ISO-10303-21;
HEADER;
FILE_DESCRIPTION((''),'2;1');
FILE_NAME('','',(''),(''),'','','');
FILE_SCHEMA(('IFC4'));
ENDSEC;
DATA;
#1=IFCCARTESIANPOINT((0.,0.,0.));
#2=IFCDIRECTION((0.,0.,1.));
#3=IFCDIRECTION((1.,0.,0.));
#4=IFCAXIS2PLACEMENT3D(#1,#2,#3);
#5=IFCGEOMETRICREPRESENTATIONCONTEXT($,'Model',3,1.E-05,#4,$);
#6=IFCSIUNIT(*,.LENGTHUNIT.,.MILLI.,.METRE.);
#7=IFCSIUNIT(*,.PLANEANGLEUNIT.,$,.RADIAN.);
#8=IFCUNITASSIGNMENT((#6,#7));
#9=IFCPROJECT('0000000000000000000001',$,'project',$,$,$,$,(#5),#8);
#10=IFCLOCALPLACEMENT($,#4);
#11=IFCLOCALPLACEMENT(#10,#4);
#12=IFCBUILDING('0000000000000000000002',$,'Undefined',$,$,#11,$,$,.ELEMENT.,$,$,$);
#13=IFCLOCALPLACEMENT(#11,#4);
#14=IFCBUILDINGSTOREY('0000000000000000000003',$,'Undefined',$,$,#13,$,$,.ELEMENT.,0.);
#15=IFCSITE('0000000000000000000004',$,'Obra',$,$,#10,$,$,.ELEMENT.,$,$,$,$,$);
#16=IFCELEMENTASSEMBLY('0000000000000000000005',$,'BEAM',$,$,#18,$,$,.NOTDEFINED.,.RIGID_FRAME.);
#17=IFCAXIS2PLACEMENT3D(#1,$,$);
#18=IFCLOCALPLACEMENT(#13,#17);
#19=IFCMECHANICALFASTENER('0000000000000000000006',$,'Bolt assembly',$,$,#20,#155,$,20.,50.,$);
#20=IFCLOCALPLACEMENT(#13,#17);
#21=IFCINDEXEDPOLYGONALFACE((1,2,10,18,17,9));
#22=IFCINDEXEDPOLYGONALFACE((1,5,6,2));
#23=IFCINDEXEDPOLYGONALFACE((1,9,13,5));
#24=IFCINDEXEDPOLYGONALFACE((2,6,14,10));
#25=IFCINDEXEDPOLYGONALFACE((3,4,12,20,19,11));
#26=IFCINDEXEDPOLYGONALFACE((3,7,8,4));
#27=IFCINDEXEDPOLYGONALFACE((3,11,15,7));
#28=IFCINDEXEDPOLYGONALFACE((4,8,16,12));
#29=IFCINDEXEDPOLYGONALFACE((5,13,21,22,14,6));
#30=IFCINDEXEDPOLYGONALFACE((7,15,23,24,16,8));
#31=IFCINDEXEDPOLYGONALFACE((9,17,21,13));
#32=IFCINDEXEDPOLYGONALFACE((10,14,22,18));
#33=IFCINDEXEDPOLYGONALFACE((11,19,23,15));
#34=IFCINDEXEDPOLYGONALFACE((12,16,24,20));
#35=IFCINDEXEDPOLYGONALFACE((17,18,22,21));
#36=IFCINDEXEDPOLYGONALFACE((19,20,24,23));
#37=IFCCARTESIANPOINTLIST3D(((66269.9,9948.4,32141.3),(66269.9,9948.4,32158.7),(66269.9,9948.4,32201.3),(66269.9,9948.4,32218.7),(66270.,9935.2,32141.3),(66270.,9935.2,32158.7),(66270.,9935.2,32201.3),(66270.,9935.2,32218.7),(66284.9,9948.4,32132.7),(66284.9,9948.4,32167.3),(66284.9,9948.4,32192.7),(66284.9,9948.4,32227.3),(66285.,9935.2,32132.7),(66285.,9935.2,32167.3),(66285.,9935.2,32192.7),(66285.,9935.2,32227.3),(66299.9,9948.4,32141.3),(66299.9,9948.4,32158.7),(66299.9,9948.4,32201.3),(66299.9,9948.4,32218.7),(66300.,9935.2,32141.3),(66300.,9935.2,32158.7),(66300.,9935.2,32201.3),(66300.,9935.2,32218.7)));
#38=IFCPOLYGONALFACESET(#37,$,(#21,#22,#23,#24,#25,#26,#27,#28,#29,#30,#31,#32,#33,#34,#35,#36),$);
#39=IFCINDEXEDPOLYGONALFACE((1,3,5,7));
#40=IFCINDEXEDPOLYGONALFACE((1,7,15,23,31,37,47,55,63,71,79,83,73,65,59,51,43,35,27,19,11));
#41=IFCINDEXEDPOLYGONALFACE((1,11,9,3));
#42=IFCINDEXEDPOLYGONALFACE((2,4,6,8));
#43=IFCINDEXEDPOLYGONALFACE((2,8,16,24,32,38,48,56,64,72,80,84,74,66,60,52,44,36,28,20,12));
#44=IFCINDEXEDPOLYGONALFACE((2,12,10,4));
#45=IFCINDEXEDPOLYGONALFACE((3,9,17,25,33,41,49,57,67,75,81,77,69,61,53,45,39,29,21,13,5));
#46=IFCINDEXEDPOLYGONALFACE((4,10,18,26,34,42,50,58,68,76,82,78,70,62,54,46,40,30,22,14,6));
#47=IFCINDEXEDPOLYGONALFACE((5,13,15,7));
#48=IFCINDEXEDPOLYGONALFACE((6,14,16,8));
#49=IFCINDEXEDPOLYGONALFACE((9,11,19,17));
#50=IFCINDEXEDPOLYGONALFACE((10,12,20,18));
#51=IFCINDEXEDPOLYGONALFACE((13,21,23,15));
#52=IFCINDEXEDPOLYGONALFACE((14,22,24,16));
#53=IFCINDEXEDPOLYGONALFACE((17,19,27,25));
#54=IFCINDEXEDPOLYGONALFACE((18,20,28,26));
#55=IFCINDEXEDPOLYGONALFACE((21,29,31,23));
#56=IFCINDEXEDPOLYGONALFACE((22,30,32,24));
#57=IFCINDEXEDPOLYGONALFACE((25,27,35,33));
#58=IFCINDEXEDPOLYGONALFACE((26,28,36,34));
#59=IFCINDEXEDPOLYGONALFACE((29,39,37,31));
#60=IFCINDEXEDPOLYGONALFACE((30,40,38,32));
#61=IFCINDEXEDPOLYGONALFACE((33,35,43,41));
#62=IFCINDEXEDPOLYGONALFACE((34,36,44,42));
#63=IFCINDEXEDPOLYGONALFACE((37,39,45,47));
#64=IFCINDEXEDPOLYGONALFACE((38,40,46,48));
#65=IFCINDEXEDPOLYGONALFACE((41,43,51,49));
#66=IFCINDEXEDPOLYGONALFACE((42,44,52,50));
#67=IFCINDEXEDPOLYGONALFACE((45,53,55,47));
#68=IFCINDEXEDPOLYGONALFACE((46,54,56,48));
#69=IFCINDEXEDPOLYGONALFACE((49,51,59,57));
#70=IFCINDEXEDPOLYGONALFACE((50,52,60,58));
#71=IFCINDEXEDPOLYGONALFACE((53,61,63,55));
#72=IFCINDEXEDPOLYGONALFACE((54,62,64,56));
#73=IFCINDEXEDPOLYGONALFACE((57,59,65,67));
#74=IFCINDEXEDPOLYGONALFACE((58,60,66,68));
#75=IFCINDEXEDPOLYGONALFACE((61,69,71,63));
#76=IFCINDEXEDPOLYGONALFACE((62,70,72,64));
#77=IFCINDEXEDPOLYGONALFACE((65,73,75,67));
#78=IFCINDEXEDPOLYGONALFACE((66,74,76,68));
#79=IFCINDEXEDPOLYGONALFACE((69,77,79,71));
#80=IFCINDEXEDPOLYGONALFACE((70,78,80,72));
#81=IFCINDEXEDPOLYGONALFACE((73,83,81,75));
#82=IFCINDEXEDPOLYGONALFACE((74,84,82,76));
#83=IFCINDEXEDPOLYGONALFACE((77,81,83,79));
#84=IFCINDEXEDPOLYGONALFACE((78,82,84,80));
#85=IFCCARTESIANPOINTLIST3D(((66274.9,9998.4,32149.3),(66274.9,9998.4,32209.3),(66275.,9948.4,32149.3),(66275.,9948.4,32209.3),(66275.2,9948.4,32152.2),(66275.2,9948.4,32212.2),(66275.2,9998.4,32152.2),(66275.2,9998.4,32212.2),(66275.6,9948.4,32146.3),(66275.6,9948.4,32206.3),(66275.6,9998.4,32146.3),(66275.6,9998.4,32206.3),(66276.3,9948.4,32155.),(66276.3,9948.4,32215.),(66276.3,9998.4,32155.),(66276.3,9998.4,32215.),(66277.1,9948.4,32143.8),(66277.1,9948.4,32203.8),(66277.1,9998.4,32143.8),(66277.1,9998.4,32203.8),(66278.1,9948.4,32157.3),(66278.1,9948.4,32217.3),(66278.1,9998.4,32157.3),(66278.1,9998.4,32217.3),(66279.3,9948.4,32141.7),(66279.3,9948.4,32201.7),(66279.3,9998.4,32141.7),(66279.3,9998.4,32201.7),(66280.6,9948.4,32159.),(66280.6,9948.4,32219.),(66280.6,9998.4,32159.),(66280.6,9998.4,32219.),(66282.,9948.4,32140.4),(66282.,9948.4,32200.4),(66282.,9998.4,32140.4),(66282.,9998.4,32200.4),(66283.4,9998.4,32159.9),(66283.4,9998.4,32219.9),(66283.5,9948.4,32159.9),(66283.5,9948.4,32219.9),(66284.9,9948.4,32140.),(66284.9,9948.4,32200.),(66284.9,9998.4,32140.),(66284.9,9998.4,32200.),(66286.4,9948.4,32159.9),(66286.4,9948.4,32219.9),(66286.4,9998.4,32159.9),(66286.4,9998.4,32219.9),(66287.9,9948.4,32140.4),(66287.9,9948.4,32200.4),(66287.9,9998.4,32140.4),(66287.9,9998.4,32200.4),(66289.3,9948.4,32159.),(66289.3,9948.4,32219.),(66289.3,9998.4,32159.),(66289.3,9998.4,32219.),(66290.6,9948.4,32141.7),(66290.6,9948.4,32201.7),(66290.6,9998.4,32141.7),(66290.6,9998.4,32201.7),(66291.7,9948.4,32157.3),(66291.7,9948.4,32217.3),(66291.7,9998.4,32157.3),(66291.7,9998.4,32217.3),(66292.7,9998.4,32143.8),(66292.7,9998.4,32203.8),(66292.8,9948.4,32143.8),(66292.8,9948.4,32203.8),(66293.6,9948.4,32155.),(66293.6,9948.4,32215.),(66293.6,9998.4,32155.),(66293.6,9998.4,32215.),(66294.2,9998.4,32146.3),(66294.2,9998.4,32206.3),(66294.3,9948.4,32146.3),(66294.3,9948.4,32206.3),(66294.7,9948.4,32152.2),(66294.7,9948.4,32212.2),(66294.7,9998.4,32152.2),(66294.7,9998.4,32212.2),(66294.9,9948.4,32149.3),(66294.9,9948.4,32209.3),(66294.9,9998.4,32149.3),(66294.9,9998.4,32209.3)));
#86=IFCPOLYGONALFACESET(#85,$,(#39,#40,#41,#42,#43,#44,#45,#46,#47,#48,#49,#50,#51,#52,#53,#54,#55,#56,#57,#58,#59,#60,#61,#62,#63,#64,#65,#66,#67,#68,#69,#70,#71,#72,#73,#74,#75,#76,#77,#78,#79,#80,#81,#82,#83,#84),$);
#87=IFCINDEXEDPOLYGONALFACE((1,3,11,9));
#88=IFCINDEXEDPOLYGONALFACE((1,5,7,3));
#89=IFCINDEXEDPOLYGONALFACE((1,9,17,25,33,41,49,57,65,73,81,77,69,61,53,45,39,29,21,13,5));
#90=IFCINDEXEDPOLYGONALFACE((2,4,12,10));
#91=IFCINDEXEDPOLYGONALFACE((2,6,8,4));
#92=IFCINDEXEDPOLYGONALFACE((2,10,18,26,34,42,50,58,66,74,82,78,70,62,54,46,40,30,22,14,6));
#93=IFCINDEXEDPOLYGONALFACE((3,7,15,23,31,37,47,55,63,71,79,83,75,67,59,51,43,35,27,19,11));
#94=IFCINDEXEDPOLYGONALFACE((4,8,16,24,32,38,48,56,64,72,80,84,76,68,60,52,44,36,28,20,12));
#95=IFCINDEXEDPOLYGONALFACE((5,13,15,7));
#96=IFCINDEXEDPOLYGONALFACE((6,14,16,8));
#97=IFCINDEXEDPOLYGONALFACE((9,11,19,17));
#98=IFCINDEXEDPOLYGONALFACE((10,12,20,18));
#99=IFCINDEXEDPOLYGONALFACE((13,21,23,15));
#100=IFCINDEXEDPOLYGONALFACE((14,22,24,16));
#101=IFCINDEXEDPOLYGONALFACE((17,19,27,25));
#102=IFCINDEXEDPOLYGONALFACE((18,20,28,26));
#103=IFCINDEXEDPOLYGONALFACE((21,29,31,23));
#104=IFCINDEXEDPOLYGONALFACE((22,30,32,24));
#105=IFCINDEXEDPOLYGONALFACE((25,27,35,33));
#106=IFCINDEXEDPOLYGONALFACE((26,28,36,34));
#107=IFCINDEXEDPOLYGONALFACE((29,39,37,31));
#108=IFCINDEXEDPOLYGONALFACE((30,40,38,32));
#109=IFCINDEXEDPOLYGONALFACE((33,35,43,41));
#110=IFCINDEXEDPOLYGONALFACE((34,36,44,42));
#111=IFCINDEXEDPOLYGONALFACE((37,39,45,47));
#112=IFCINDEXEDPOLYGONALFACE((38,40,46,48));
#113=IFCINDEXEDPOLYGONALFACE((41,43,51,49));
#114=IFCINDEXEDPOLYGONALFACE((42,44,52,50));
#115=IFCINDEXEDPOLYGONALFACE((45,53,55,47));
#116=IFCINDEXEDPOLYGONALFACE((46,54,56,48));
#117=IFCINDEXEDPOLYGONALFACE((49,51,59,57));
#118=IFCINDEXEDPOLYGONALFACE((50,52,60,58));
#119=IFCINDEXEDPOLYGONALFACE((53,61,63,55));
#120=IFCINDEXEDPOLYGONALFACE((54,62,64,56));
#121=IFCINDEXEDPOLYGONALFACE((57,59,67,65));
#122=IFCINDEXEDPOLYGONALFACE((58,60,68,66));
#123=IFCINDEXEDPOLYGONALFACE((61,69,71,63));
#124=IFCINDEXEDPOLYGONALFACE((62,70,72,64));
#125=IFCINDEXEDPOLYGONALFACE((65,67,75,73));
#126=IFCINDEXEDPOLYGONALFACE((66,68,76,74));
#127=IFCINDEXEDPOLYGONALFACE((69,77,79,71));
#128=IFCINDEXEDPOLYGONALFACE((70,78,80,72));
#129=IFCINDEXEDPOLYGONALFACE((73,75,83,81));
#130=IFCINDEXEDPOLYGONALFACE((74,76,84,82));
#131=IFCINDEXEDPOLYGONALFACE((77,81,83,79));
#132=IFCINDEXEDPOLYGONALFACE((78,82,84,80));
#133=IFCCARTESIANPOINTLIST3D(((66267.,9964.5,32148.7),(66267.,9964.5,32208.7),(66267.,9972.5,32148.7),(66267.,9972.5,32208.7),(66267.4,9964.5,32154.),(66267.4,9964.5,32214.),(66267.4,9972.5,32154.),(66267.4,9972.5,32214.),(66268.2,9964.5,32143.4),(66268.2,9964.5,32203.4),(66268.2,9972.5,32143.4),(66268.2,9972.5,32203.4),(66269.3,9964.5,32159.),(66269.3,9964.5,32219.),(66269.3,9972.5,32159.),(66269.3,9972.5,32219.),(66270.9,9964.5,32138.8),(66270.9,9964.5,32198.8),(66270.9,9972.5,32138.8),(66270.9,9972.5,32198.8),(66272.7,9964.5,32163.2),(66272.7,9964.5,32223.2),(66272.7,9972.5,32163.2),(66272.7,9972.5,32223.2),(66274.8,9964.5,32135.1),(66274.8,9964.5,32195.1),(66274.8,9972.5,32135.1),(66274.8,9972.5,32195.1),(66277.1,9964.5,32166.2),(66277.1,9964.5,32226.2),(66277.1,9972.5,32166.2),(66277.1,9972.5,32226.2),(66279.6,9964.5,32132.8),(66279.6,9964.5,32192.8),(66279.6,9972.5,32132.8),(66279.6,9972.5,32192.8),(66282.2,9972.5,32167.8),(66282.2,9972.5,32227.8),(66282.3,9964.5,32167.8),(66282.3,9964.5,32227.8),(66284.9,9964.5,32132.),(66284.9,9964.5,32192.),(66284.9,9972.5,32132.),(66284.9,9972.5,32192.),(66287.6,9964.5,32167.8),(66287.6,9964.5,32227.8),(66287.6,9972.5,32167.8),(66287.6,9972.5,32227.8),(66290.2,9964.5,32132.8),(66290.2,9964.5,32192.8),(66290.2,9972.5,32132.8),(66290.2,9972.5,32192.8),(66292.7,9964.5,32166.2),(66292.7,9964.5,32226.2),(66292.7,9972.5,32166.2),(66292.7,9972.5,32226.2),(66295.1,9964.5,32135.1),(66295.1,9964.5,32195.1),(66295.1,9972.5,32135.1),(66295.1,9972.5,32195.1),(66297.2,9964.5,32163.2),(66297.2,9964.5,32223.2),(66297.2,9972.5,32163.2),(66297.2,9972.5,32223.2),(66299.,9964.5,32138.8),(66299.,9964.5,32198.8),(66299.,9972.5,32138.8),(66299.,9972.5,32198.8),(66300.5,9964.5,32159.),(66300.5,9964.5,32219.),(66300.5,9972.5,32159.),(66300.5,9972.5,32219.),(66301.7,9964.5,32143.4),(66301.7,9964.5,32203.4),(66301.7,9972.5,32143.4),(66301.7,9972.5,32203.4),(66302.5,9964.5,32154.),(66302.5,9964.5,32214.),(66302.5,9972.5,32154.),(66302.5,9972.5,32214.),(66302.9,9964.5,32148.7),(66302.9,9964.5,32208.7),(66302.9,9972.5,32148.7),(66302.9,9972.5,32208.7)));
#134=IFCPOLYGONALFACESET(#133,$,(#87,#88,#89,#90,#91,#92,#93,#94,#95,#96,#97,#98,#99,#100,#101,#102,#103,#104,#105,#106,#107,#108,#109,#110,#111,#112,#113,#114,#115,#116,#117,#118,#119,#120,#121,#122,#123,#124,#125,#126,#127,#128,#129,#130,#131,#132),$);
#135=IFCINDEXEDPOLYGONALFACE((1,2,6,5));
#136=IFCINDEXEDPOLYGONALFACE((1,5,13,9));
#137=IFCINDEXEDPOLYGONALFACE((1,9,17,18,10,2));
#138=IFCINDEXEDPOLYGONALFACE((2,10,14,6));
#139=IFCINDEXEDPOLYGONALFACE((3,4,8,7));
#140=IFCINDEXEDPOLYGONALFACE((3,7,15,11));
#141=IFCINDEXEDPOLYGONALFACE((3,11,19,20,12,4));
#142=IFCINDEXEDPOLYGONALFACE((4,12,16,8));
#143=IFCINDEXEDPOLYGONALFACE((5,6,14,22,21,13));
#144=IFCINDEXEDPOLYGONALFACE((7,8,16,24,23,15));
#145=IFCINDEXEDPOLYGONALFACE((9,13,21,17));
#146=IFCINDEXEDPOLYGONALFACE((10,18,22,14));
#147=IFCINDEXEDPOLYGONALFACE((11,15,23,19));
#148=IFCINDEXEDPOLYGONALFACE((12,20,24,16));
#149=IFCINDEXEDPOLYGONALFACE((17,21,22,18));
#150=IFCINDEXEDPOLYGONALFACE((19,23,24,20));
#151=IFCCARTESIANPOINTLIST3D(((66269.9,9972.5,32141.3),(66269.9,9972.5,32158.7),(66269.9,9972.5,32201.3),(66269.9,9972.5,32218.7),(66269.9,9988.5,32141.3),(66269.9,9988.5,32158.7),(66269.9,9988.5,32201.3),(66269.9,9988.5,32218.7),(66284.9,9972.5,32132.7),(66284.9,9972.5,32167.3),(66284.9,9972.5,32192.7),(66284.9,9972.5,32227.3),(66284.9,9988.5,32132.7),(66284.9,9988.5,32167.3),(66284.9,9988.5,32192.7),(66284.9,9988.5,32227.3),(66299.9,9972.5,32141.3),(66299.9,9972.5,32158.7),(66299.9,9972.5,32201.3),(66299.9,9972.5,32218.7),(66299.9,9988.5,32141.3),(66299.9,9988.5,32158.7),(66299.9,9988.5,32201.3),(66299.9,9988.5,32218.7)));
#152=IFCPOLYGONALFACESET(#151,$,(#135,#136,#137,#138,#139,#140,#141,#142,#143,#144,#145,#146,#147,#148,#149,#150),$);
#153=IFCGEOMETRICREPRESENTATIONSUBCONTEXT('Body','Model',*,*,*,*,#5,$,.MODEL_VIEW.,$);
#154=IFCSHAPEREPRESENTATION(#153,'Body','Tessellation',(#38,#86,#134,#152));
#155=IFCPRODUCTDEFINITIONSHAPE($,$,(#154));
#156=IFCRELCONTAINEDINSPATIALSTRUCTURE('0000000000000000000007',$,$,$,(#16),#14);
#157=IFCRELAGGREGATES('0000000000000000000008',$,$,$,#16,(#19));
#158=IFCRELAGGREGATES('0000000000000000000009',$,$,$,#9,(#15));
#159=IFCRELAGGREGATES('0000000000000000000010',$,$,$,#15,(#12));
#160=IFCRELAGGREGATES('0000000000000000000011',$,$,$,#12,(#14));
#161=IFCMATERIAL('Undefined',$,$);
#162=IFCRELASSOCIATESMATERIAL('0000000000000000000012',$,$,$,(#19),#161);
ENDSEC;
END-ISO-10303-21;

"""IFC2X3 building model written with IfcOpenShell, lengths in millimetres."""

from ifc_helpers import new_model, si_unit, frame, origin_with_axes, origin_2d_with_axis, place, context, subcontext, project, spatial, polyline, circle, outline, extrude, source, transform, mapped, material, element, aggregate, save


model = new_model("IFC2X3")

# Units and contexts
model_context = context("Model", 3, precision=1e-05, world=origin_with_axes())
body_context = subcontext(model_context, "Body", "Model", "MODEL_VIEW")
ifc_project = project(units=[si_unit("LENGTHUNIT", "METRE", prefix="MILLI"), si_unit("PLANEANGLEUNIT", "RADIAN")], contexts=[model_context])

# Site, building, storey
site_placement = place(None, origin_with_axes())
site = spatial("IfcSite", under=ifc_project, at=site_placement, Name="Obra", CompositionType="ELEMENT")
building_placement = place(site_placement, origin_with_axes())
building = spatial("IfcBuilding", under=site, at=building_placement, Name="Undefined", CompositionType="ELEMENT")
storey_placement = place(building_placement, origin_with_axes())
storey = spatial("IfcBuildingStorey", under=building, at=storey_placement, Name="Undefined", CompositionType="ELEMENT", Elevation=0.0)

# Element assembly
assembly_1_placement = place(storey_placement, origin_with_axes())
assembly_1 = element("IfcElementAssembly", 1, at=assembly_1_placement, inside=storey, Name="BEAM", AssemblyPlace="NOTDEFINED", PredefinedType="RIGID_FRAME")

# Mechanical fastener
ifc_material_1 = material(Name="Undefined")
shared_shape_1 = source(origin_with_axes(), body_context, "Body", "SweptSolid", [
    extrude(outline(polyline([(17.3, 0.0), (8.7, 15.0), (-8.7, 15.0), (-17.3, 0.0), (-8.7, -15.0), (8.7, -15.0), (17.3, 0.0)])), frame((0.0, -26.5, 0.0), z_axis=(0.0, 1.0, 0.0), x_axis=(1.0, 0.0, 0.0)), (0.0, 0.0, 1.0), 13.2),
    extrude(circle(Radius=10.0, at=origin_2d_with_axis()), frame((0.0, -13.3, 0.0), z_axis=(0.0, 1.0, 0.0), x_axis=(1.0, 0.0, 0.0)), (0.0, 0.0, 1.0), 50.0),
    extrude(circle(Radius=18.0, at=origin_2d_with_axis()), frame((0.0, 2.9, 0.0), z_axis=(0.0, 1.0, 0.0), x_axis=(1.0, 0.0, 0.0)), (0.0, 0.0, 1.0), 8.0),
    extrude(outline(polyline([(17.3, 0.0), (8.7, 15.0), (-8.7, 15.0), (-17.3, 0.0), (-8.7, -15.0), (8.7, -15.0), (17.3, 0.0)])), frame((0.0, 10.9, 0.0), z_axis=(0.0, 1.0, 0.0), x_axis=(1.0, 0.0, 0.0)), (0.0, 0.0, 1.0), 16.0),
])
mechanical_fastener_1_placement = place(assembly_1_placement, frame((66244.9, 9961.6, 32250.0), z_axis=(1.0, 0.000588, 0.0), x_axis=(0.0, 0.0, -1.0)))
mechanical_fastener_1 = element("IfcMechanicalFastener", 2, at=mechanical_fastener_1_placement, material=ifc_material_1, Name="Bolt assembly", NominalDiameter=20.0, NominalLength=50.0, context=body_context, shape_type="MappedRepresentation", body=[
    mapped(shared_shape_1, transform((40.0, 0.0, 40.0))),
    mapped(shared_shape_1, transform((100.0, 0.0, 40.0))),
])

aggregate(assembly_1, [mechanical_fastener_1])

save(model, "model.ifc")
